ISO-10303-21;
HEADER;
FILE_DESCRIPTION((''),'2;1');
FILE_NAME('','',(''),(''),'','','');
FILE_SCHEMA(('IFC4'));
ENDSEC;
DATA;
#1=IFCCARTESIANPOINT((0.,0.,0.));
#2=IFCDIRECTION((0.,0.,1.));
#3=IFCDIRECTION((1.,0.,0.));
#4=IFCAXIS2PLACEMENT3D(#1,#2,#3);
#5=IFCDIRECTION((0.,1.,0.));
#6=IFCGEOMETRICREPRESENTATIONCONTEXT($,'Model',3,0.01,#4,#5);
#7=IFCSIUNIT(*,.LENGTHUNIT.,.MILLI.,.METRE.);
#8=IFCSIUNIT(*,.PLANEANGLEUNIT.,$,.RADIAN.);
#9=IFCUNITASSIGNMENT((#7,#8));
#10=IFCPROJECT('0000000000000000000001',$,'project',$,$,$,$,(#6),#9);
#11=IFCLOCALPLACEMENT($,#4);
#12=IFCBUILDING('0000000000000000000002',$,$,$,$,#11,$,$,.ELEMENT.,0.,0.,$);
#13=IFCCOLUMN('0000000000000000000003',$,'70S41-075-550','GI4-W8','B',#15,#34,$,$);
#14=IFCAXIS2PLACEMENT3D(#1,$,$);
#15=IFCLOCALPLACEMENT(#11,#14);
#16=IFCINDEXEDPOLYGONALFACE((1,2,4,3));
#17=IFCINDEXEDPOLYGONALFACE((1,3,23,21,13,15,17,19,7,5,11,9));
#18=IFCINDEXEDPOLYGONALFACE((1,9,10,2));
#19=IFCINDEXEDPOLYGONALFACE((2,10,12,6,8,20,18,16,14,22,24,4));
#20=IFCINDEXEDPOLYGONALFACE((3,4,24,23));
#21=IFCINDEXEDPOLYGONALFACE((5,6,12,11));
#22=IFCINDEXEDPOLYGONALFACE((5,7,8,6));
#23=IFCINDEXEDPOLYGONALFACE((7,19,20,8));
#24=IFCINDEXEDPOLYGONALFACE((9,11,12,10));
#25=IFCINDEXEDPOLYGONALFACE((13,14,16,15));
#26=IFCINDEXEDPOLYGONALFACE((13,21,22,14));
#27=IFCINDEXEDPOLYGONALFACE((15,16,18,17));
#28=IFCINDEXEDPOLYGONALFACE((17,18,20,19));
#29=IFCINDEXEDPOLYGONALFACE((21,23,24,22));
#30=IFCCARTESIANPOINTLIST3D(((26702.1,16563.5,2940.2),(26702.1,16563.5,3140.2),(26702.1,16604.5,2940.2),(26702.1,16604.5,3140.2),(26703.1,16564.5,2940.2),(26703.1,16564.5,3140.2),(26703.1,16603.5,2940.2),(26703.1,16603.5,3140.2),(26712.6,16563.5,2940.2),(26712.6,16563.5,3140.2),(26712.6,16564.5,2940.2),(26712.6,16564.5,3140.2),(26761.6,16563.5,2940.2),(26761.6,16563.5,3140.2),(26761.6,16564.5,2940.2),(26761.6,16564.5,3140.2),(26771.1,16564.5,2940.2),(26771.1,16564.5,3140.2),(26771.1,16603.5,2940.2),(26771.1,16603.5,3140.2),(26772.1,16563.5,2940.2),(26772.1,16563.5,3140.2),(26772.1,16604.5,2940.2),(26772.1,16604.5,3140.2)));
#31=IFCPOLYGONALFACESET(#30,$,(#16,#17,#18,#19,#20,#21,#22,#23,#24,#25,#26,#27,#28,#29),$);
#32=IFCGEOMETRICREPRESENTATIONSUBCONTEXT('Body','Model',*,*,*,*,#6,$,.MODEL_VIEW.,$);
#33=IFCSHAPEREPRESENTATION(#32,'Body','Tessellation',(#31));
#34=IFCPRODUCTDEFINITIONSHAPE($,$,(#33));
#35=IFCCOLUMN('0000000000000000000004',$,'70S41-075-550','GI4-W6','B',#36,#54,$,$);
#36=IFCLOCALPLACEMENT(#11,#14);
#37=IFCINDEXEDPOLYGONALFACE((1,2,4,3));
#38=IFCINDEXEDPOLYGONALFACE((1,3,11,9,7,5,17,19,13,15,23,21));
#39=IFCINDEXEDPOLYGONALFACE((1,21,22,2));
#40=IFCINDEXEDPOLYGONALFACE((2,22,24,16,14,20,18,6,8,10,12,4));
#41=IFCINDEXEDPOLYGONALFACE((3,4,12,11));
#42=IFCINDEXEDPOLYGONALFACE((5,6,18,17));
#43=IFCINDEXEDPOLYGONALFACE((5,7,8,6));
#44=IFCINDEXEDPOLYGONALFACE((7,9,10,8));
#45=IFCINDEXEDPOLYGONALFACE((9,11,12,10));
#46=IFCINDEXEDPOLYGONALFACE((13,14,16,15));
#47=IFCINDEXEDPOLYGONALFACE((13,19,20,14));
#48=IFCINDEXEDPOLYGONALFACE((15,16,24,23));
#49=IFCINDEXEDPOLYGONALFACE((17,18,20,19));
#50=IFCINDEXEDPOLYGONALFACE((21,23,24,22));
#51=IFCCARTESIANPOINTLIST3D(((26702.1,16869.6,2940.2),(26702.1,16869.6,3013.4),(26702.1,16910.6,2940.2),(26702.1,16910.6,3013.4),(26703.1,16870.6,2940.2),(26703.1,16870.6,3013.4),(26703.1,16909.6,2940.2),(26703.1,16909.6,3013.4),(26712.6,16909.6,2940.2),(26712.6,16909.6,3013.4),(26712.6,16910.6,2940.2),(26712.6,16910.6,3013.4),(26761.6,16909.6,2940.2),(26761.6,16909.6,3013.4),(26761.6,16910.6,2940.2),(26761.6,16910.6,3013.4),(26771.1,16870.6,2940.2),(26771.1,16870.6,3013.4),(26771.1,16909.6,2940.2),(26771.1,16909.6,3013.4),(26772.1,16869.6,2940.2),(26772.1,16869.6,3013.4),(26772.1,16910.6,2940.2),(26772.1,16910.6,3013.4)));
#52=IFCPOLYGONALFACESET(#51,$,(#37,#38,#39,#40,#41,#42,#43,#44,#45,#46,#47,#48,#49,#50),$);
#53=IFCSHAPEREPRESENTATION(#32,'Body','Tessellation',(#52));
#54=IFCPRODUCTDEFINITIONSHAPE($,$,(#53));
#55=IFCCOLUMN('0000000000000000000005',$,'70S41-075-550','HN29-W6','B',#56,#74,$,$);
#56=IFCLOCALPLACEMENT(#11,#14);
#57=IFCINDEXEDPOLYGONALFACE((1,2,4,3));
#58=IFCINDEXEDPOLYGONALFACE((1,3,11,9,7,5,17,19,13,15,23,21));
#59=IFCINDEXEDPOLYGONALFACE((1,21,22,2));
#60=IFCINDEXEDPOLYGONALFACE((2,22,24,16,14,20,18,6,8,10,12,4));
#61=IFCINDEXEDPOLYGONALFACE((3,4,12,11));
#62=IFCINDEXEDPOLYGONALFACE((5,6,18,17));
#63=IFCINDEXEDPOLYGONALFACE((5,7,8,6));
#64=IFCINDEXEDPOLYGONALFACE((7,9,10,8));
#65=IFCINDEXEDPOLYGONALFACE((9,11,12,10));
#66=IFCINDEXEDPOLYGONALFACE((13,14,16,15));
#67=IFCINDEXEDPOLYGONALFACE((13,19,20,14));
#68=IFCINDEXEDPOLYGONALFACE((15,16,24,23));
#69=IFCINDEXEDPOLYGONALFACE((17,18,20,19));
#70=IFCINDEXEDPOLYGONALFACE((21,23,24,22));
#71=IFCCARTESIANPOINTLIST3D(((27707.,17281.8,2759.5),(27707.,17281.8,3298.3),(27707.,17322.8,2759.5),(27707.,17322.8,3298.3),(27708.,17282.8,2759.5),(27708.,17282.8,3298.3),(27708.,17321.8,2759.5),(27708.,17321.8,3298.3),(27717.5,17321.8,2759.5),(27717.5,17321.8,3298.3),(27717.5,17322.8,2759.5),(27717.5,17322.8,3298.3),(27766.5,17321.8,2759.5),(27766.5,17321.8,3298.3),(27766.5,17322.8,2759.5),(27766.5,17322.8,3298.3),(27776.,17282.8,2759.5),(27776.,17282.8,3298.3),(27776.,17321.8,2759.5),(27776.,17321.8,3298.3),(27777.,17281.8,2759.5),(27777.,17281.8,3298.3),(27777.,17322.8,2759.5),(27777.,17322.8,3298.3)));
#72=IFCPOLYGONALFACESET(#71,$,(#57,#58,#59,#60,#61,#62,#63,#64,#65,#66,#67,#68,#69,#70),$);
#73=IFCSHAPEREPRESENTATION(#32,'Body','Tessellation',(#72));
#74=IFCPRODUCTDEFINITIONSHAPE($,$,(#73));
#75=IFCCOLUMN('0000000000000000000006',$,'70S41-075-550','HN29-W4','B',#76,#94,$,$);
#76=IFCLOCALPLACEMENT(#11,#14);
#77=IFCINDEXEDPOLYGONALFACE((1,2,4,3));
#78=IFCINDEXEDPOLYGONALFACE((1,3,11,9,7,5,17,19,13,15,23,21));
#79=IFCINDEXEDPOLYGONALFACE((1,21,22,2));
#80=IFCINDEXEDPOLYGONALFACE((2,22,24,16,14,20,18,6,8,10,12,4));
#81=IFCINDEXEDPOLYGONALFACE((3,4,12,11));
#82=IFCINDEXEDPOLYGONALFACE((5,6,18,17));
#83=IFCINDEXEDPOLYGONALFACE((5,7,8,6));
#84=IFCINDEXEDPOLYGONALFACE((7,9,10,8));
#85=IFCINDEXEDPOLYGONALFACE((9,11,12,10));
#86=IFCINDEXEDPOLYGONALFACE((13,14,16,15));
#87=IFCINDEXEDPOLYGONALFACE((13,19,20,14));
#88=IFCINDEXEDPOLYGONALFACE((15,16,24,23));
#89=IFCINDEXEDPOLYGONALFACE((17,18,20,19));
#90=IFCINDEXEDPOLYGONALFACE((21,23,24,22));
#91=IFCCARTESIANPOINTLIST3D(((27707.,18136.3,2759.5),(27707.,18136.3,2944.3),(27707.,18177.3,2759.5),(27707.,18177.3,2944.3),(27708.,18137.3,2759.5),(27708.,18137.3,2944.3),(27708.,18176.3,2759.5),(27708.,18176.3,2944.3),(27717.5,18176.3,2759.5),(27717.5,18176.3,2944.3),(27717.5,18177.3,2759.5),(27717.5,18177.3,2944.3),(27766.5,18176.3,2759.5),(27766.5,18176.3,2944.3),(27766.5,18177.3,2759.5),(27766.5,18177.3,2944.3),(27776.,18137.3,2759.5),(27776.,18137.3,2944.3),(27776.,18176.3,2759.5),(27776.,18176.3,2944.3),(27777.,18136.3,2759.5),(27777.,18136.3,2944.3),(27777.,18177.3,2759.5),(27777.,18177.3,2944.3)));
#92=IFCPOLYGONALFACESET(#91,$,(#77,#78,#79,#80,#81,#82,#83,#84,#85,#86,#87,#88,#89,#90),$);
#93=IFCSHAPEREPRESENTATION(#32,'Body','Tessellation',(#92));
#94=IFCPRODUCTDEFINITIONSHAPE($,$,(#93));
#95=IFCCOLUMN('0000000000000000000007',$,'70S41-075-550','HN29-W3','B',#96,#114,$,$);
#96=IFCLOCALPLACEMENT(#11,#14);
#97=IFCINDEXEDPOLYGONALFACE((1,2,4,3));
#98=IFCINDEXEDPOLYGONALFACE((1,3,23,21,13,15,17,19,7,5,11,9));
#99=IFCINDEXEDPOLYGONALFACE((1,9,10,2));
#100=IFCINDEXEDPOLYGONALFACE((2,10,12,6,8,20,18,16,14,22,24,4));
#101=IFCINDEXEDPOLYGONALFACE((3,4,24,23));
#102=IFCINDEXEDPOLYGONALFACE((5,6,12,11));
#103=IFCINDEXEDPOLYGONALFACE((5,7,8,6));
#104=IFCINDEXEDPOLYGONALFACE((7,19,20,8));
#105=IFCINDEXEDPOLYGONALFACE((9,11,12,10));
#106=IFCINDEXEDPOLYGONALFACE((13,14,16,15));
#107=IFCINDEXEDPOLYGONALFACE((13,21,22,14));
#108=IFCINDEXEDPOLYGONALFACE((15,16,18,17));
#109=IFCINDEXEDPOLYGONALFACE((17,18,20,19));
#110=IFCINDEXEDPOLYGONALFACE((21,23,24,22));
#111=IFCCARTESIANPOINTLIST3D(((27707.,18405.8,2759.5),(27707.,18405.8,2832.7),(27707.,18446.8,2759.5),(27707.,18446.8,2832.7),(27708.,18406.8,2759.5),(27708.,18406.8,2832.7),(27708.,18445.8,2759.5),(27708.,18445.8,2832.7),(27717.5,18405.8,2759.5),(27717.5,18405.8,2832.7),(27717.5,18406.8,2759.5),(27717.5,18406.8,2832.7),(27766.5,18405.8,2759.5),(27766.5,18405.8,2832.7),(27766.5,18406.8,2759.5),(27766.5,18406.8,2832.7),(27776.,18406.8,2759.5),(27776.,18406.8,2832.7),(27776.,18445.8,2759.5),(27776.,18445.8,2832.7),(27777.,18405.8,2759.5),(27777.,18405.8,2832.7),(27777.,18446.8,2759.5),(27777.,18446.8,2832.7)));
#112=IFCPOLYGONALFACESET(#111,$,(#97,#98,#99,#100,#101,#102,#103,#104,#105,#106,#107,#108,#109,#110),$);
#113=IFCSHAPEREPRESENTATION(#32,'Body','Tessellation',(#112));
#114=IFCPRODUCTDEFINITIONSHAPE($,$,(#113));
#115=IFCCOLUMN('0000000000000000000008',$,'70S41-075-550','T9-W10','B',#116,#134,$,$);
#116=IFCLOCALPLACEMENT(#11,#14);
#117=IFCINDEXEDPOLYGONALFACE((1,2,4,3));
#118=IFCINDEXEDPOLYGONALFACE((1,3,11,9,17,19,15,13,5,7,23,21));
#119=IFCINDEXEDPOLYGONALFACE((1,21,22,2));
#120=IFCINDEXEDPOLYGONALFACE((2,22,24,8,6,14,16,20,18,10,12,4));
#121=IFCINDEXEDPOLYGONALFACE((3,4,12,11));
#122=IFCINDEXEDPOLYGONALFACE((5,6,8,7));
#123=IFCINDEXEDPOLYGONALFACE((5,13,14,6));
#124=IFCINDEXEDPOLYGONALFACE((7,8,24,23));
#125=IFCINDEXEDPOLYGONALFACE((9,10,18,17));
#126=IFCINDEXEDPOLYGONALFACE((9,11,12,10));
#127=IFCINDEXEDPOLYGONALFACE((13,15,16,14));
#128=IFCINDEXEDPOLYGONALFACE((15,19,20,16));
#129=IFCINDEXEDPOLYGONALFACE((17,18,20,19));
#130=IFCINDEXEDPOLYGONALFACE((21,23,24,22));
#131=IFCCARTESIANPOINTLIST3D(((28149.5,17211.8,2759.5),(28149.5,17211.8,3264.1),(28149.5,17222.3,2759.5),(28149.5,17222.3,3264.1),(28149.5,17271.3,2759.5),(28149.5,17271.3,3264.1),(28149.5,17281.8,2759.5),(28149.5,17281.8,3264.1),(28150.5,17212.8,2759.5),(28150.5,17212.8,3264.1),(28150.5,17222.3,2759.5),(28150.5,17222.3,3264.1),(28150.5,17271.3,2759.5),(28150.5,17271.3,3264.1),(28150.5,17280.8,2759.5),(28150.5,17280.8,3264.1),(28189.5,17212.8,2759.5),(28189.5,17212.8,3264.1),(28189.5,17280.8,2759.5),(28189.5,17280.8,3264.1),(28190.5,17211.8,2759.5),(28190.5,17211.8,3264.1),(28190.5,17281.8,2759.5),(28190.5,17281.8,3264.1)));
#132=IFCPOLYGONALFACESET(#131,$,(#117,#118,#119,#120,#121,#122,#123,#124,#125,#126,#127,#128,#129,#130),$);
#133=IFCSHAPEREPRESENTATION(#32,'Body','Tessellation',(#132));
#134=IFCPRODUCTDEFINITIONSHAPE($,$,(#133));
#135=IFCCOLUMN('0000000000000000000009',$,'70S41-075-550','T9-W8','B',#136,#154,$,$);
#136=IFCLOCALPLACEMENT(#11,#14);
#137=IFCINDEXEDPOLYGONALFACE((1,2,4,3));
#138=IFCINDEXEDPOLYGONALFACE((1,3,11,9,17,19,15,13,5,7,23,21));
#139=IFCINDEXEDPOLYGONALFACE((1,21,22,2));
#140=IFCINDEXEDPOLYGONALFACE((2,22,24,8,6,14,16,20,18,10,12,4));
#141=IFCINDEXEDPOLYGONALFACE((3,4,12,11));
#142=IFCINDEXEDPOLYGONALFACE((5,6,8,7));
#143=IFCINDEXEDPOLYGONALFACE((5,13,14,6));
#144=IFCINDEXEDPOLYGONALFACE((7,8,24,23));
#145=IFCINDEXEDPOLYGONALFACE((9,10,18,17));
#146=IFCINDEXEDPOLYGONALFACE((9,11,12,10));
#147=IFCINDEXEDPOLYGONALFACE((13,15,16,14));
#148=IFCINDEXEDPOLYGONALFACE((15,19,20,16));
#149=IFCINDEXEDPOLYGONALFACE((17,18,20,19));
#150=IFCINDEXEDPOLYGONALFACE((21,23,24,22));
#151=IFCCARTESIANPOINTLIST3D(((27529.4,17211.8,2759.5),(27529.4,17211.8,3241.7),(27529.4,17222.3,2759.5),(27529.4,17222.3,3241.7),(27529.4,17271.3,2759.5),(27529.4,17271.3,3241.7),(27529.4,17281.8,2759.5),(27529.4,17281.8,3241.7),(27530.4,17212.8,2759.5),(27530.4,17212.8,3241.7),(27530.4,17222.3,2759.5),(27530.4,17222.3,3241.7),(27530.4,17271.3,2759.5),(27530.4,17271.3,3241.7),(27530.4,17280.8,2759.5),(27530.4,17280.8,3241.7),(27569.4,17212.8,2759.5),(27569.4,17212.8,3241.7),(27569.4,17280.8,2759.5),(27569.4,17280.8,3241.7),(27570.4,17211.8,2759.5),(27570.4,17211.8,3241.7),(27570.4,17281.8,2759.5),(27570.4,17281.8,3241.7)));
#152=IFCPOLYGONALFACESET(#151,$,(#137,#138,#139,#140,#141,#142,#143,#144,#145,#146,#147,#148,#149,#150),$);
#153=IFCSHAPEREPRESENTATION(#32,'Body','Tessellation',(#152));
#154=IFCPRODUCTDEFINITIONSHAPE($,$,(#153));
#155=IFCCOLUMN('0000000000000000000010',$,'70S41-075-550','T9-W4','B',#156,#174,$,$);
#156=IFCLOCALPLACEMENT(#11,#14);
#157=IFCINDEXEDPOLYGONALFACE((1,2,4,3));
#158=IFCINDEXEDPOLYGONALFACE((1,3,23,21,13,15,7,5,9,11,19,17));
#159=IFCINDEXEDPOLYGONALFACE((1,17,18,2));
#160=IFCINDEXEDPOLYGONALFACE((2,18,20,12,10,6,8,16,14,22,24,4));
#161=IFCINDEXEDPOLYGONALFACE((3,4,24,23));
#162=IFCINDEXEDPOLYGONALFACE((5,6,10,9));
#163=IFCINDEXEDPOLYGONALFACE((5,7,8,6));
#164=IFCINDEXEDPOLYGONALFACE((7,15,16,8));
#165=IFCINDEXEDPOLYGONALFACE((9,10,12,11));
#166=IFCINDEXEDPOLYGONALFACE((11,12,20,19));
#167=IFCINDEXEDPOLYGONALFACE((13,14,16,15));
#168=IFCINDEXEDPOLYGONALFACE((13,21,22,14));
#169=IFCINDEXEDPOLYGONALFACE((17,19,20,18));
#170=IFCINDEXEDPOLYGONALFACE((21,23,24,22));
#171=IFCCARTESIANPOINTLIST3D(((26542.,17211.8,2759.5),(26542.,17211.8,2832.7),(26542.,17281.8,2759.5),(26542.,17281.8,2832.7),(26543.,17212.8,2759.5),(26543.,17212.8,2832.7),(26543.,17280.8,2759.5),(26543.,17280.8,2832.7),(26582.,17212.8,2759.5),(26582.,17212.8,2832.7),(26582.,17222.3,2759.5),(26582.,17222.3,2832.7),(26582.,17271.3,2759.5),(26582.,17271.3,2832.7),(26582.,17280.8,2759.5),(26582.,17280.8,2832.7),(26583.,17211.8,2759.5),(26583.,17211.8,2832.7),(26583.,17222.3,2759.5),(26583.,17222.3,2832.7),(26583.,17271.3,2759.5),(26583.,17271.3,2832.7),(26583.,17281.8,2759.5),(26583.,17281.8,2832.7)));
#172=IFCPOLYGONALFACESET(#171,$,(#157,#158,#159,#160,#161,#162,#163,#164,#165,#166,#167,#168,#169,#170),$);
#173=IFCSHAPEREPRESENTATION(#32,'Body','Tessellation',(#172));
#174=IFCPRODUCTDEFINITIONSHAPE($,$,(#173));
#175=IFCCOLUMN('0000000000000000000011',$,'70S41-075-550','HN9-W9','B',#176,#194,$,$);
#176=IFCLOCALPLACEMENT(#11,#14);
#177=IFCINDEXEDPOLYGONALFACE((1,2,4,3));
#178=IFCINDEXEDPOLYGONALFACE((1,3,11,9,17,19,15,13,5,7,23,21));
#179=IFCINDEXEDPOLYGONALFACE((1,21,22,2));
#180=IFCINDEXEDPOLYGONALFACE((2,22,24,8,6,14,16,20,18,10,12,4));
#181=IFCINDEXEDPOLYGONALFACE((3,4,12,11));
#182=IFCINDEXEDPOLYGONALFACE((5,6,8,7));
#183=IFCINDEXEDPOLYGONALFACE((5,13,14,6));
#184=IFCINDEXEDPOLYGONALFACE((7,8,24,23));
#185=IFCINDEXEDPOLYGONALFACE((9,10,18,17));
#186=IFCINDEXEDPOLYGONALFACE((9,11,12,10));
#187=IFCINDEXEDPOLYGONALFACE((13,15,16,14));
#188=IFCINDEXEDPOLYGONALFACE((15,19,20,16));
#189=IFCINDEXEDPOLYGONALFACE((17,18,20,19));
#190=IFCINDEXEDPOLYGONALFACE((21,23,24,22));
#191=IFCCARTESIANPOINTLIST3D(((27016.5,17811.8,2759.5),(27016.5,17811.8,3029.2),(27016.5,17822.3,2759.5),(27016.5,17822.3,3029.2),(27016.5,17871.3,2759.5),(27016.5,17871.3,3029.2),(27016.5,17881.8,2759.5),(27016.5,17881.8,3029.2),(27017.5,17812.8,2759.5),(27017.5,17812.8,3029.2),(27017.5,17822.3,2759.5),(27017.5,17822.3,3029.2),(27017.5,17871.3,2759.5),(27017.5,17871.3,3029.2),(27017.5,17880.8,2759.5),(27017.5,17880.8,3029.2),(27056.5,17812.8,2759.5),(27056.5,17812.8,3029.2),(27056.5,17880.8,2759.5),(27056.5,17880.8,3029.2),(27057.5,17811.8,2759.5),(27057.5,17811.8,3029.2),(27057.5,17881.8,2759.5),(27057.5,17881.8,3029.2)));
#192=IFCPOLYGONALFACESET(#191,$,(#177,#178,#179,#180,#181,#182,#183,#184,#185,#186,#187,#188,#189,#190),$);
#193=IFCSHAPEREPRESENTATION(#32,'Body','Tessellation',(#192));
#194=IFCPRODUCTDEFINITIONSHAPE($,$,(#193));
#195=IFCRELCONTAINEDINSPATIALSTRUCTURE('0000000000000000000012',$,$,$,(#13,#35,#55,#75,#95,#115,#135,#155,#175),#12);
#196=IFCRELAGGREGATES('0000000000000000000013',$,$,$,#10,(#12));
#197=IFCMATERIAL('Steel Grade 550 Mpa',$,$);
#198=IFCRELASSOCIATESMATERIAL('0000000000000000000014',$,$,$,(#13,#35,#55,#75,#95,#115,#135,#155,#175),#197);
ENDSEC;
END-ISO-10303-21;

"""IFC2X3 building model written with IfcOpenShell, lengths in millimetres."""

from ifc_helpers import new_model, si_unit, direction, frame, origin, origin_with_axes, origin_2d_with_axis, place, context, subcontext, project, spatial, c_section, extrude, source, transform, mapped, material, element, save


model = new_model("IFC2X3")

# Units and contexts
model_context = context("Model", 3, precision=0.01, world=origin_with_axes(), true_north=direction((0.0, 1.0, 0.0)))
body_context = subcontext(model_context, "Body", "Model", "MODEL_VIEW")
ifc_project = project(units=[si_unit("LENGTHUNIT", "METRE", prefix="MILLI"), si_unit("PLANEANGLEUNIT", "RADIAN")], contexts=[model_context])

# Building
building_placement = place(None, origin_with_axes())
building = spatial("IfcBuilding", under=ifc_project, at=building_placement, CompositionType="ELEMENT", ElevationOfRefHeight=0.0, ElevationOfTerrain=0.0)

# Columns
ifc_material = material(Name="Steel Grade 550 Mpa")
shared_shape_1 = source(origin(), body_context, "Body", "SweptSolid", [
    extrude(c_section(Depth=70.0, Width=41.0, WallThickness=1.0, Girth=10.5, at=origin_2d_with_axis()), origin_with_axes(), (0.0, 0.0, 1.0), 200.0),
])
column_1_placement = place(None, frame((26737.1, 16584.0, 3140.2), z_axis=(0.0, 0.0, -1.0), x_axis=(0.0, -1.0, 0.0)))
element("IfcColumn", 1, at=column_1_placement, inside=building, material=ifc_material, Name="70S41-075-550", Description="GI4-W8", ObjectType="B", context=body_context, shape_type="MappedRepresentation", body=[
    mapped(shared_shape_1, transform((0.0, 0.0, 0.0), scale=1.0)),
])
shared_shape_2 = source(origin(), body_context, "Body", "SweptSolid", [
    extrude(c_section(Depth=70.0, Width=41.0, WallThickness=1.0, Girth=10.5, at=origin_2d_with_axis()), origin_with_axes(), (0.0, 0.0, 1.0), 73.2),
])
column_2_placement = place(None, frame((26737.1, 16890.1, 2940.2), z_axis=(0.0, 0.0, 1.0), x_axis=(0.0, 1.0, 0.0)))
element("IfcColumn", 2, at=column_2_placement, inside=building, material=ifc_material, Name="70S41-075-550", Description="GI4-W6", ObjectType="B", context=body_context, shape_type="MappedRepresentation", body=[
    mapped(shared_shape_2, transform((0.0, 0.0, 0.0), scale=1.0)),
])
shared_shape_3 = source(origin(), body_context, "Body", "SweptSolid", [
    extrude(c_section(Depth=70.0, Width=41.0, WallThickness=1.0, Girth=10.5, at=origin_2d_with_axis()), origin_with_axes(), (0.0, 0.0, 1.0), 538.8),
])
column_3_placement = place(None, frame((27742.0, 17302.3, 2759.5), z_axis=(0.0, 0.0, 1.0), x_axis=(0.0, 1.0, 0.0)))
element("IfcColumn", 3, at=column_3_placement, inside=building, material=ifc_material, Name="70S41-075-550", Description="HN29-W6", ObjectType="B", context=body_context, shape_type="MappedRepresentation", body=[
    mapped(shared_shape_3, transform((0.0, 0.0, 0.0), scale=1.0)),
])
shared_shape_4 = source(origin(), body_context, "Body", "SweptSolid", [
    extrude(c_section(Depth=70.0, Width=41.0, WallThickness=1.0, Girth=10.5, at=origin_2d_with_axis()), origin_with_axes(), (0.0, 0.0, 1.0), 184.8),
])
column_4_placement = place(None, frame((27742.0, 18156.8, 2759.5), z_axis=(0.0, 0.0, 1.0), x_axis=(0.0, 1.0, 0.0)))
element("IfcColumn", 4, at=column_4_placement, inside=building, material=ifc_material, Name="70S41-075-550", Description="HN29-W4", ObjectType="B", context=body_context, shape_type="MappedRepresentation", body=[
    mapped(shared_shape_4, transform((0.0, 0.0, 0.0), scale=1.0)),
])
shared_shape_5 = source(origin(), body_context, "Body", "SweptSolid", [
    extrude(c_section(Depth=70.0, Width=41.0, WallThickness=1.0, Girth=10.5, at=origin_2d_with_axis()), origin_with_axes(), (0.0, 0.0, 1.0), 73.2),
])
column_5_placement = place(None, frame((27742.0, 18426.3, 2832.7), z_axis=(0.0, 0.0, -1.0), x_axis=(0.0, -1.0, 0.0)))
element("IfcColumn", 5, at=column_5_placement, inside=building, material=ifc_material, Name="70S41-075-550", Description="HN29-W3", ObjectType="B", context=body_context, shape_type="MappedRepresentation", body=[
    mapped(shared_shape_5, transform((0.0, 0.0, 0.0), scale=1.0)),
])
shared_shape_6 = source(origin(), body_context, "Body", "SweptSolid", [
    extrude(c_section(Depth=70.0, Width=41.0, WallThickness=1.0, Girth=10.5, at=origin_2d_with_axis()), origin_with_axes(), (0.0, 0.0, 1.0), 504.6),
])
column_6_placement = place(None, frame((28170.0, 17246.8, 2759.5), z_axis=(0.0, 0.0, 1.0), x_axis=(-1.0, 0.0, 0.0)))
element("IfcColumn", 6, at=column_6_placement, inside=building, material=ifc_material, Name="70S41-075-550", Description="T9-W10", ObjectType="B", context=body_context, shape_type="MappedRepresentation", body=[
    mapped(shared_shape_6, transform((0.0, 0.0, 0.0), scale=1.0)),
])
shared_shape_7 = source(origin(), body_context, "Body", "SweptSolid", [
    extrude(c_section(Depth=70.0, Width=41.0, WallThickness=1.0, Girth=10.5, at=origin_2d_with_axis()), origin_with_axes(), (0.0, 0.0, 1.0), 482.2),
])
column_7_placement = place(None, frame((27549.9, 17246.8, 2759.5), z_axis=(0.0, 0.0, 1.0), x_axis=(-1.0, 0.0, 0.0)))
element("IfcColumn", 7, at=column_7_placement, inside=building, material=ifc_material, Name="70S41-075-550", Description="T9-W8", ObjectType="B", context=body_context, shape_type="MappedRepresentation", body=[
    mapped(shared_shape_7, transform((0.0, 0.0, 0.0), scale=1.0)),
])
shared_shape_8 = source(origin(), body_context, "Body", "SweptSolid", [
    extrude(c_section(Depth=70.0, Width=41.0, WallThickness=1.0, Girth=10.5, at=origin_2d_with_axis()), origin_with_axes(), (0.0, 0.0, 1.0), 73.2),
])
column_8_placement = place(None, frame((26562.5, 17246.8, 2832.7), z_axis=(0.0, 0.0, -1.0), x_axis=(1.0, 0.0, 0.0)))
element("IfcColumn", 8, at=column_8_placement, inside=building, material=ifc_material, Name="70S41-075-550", Description="T9-W4", ObjectType="B", context=body_context, shape_type="MappedRepresentation", body=[
    mapped(shared_shape_8, transform((0.0, 0.0, 0.0), scale=1.0)),
])
shared_shape_9 = source(origin(), body_context, "Body", "SweptSolid", [
    extrude(c_section(Depth=70.0, Width=41.0, WallThickness=1.0, Girth=10.5, at=origin_2d_with_axis()), origin_with_axes(), (0.0, 0.0, 1.0), 269.7),
])
column_9_placement = place(None, frame((27037.0, 17846.8, 2759.5), z_axis=(0.0, 0.0, 1.0), x_axis=(-1.0, 0.0, 0.0)))
element("IfcColumn", 9, at=column_9_placement, inside=building, material=ifc_material, Name="70S41-075-550", Description="HN9-W9", ObjectType="B", context=body_context, shape_type="MappedRepresentation", body=[
    mapped(shared_shape_9, transform((0.0, 0.0, 0.0), scale=1.0)),
])

save(model, "model.ifc")
